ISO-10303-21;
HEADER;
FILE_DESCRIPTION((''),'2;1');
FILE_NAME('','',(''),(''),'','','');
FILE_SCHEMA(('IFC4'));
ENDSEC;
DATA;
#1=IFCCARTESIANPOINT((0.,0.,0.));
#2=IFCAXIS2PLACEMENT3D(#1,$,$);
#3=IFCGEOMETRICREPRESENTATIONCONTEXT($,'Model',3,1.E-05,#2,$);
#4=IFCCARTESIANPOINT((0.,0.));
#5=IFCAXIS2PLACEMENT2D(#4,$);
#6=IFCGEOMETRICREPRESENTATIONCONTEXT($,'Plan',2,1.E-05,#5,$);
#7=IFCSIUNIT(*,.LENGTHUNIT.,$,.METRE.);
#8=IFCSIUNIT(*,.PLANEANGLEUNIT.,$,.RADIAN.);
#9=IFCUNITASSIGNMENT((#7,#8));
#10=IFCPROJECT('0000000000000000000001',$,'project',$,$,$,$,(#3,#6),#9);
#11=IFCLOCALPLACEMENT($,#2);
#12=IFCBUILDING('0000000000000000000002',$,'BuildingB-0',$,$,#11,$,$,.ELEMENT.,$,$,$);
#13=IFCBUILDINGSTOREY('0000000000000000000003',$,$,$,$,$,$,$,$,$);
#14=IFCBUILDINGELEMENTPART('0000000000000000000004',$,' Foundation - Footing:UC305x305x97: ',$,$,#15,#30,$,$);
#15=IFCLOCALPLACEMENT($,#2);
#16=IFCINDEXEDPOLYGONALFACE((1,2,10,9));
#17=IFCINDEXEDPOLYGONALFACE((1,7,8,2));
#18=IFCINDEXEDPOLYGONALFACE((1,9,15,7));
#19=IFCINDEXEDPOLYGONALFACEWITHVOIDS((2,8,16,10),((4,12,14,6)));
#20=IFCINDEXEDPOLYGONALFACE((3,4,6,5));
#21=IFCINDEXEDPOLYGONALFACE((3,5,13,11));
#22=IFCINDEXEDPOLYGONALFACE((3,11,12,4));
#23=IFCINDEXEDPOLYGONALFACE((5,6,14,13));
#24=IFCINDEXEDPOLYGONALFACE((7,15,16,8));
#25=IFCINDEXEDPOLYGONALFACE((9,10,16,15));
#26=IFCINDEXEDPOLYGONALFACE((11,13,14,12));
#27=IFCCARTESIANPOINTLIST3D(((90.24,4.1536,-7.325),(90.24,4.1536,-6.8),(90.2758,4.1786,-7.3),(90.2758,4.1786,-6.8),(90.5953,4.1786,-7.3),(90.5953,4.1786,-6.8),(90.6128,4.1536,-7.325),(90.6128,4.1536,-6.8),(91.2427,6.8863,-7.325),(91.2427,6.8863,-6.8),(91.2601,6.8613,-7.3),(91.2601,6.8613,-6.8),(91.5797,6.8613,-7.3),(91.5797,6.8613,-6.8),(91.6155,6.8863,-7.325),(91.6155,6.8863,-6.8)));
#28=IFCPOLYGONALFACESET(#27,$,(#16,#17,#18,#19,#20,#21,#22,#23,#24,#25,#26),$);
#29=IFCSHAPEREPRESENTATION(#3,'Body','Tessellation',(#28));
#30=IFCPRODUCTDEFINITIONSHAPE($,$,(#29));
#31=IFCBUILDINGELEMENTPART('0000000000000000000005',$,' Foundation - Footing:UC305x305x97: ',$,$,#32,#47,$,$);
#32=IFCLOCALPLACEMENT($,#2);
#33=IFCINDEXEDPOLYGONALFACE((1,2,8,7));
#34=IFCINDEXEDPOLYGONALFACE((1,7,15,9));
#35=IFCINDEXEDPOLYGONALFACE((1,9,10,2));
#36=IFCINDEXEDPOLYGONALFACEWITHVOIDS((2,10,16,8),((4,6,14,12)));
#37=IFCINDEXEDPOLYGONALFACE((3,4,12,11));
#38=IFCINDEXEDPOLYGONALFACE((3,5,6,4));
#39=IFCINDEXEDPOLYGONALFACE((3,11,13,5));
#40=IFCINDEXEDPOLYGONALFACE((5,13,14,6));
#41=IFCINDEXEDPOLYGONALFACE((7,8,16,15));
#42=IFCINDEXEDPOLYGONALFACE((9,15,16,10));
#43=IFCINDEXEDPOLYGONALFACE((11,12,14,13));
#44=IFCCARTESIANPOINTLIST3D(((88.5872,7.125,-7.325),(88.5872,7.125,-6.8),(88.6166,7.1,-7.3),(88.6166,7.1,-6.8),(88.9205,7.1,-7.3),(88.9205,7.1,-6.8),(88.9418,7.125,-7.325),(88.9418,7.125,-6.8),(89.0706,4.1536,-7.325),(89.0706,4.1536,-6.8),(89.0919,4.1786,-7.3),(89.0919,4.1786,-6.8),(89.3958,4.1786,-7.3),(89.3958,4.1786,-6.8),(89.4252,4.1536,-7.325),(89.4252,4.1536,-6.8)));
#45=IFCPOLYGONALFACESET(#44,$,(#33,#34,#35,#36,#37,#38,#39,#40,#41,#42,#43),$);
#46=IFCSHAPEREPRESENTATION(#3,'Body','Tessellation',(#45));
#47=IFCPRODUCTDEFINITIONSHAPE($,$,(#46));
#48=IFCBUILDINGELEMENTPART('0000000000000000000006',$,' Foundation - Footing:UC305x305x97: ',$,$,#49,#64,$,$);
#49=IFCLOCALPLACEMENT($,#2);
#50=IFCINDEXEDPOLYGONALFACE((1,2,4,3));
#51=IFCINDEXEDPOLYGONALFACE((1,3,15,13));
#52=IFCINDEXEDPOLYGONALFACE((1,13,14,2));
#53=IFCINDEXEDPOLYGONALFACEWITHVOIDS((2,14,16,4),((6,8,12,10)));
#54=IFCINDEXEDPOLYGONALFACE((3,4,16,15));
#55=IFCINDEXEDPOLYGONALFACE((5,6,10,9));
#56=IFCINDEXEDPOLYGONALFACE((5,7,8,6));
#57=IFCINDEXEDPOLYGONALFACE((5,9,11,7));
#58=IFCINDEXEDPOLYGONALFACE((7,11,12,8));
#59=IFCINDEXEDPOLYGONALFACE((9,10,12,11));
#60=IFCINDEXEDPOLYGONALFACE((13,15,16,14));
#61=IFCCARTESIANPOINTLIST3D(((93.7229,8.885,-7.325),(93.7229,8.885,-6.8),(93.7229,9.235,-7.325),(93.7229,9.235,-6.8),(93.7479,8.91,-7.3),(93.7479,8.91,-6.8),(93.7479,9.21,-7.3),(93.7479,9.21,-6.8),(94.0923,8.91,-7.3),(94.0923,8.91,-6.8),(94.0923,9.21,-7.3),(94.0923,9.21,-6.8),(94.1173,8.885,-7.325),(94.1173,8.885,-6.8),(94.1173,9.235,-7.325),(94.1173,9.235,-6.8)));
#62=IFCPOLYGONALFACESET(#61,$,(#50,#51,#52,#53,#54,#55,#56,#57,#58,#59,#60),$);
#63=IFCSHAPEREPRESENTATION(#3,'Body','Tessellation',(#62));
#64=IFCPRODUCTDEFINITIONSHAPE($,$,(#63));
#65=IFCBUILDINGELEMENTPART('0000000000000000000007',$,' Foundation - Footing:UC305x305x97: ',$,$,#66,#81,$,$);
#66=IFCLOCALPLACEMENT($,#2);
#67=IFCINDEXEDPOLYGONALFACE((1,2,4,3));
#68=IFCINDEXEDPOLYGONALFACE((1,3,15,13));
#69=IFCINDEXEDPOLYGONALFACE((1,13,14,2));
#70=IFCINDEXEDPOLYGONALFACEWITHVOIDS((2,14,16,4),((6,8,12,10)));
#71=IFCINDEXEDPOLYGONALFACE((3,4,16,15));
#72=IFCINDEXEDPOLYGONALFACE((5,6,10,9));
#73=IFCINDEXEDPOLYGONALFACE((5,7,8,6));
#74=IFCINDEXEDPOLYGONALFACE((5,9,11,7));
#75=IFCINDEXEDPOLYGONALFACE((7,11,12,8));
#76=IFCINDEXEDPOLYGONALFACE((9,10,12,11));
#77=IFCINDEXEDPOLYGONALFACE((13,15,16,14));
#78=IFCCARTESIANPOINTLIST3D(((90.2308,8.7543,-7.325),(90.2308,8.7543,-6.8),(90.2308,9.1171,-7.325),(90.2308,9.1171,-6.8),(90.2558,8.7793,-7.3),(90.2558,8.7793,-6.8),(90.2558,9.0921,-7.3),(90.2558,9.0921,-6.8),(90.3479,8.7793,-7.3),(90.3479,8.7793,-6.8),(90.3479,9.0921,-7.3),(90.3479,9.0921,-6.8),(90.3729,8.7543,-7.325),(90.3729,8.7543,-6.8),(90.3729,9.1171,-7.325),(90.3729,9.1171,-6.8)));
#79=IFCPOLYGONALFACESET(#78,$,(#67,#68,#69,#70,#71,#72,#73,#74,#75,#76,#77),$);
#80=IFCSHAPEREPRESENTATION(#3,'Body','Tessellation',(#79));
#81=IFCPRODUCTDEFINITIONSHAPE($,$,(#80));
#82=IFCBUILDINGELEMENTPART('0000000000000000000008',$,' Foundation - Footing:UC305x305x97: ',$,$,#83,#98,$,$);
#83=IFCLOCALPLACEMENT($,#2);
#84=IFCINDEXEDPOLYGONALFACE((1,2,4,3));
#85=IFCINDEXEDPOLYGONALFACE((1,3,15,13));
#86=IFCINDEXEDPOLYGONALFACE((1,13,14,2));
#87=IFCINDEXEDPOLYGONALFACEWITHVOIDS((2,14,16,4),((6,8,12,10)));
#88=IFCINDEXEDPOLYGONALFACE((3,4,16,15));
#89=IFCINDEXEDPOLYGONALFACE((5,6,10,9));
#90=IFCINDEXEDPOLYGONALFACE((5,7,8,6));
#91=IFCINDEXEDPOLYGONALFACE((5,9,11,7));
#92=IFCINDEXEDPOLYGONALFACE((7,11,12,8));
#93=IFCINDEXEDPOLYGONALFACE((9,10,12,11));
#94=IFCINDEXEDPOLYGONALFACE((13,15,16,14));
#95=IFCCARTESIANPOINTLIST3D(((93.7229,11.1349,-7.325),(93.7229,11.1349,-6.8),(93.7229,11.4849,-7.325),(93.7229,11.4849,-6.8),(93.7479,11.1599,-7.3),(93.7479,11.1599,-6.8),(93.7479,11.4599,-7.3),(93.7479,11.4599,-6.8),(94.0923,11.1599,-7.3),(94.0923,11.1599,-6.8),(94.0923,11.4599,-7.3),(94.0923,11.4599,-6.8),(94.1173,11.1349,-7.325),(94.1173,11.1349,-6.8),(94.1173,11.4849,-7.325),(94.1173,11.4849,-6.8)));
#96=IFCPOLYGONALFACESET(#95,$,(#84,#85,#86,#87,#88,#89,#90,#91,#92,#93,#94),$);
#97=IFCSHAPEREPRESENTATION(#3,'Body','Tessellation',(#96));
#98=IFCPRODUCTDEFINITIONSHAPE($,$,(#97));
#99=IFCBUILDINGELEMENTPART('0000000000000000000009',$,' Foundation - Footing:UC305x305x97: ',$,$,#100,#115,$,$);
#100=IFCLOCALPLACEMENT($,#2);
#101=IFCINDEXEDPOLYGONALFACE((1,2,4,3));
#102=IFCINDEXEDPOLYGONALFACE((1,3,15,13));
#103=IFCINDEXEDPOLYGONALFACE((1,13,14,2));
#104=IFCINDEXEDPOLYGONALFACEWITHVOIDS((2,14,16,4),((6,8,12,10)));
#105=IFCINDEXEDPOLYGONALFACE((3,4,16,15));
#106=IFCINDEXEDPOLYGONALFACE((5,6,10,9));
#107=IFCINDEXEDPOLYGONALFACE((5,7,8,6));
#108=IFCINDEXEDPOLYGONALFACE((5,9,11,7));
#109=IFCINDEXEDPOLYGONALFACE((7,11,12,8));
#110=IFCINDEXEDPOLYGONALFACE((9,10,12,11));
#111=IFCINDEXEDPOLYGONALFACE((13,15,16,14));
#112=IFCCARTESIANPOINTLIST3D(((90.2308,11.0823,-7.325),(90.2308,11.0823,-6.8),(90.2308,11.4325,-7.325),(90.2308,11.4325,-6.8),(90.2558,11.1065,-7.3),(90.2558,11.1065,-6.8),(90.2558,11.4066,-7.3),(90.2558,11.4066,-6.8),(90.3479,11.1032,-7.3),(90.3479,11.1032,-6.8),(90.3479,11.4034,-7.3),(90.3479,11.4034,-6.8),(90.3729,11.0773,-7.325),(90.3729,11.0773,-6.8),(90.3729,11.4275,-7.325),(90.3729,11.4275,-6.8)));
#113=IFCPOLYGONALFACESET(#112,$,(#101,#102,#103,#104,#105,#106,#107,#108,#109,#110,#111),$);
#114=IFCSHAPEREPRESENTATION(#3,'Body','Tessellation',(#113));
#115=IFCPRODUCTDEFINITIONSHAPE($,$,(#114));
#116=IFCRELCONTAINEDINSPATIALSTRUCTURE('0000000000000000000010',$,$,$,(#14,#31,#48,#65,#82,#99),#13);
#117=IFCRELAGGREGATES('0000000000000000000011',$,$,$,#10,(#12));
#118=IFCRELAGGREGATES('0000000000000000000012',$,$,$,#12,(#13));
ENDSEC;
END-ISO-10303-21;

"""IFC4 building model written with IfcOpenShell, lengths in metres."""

from ifc_helpers import new_model, si_unit, origin, origin_2d, place, context, project, spatial, polyline, outline, extrude, element, save


model = new_model("IFC4")

# Units and contexts
model_context = context("Model", 3, precision=1e-05, world=origin())
plan_context = context("Plan", 2, precision=1e-05, world=origin_2d())
ifc_project = project(units=[si_unit("LENGTHUNIT", "METRE"), si_unit("PLANEANGLEUNIT", "RADIAN")], contexts=[model_context, plan_context])

# Building, storey
building_placement = place(None, origin())
building = spatial("IfcBuilding", under=ifc_project, at=building_placement, Name="BuildingB-0", CompositionType="ELEMENT")
storey = spatial("IfcBuildingStorey", under=building)

# Building element parts, openings
building_element_part_1 = element("IfcBuildingElementPart", 1, inside=storey, Name=" Foundation - Footing:UC305x305x97: ", context=model_context, shape_type="SweptSolid", body=[
    extrude(outline(polyline([(90.6128, 4.1536, -7.325), (90.24, 4.1536, -7.325), (91.2427, 6.8863, -7.325), (91.6155, 6.8863, -7.325), (90.6128, 4.1536, -7.325)])), None, (0.0, 0.0, 1.0), 0.525),
])
element("IfcOpeningElement", 2, inside=storey, cuts=building_element_part_1, context=model_context, shape_type="SweptSolid", body=[
    extrude(outline(polyline([(90.5953, 4.1786, -7.3), (90.2758, 4.1786, -7.3), (91.2601, 6.8613, -7.3), (91.5797, 6.8613, -7.3), (90.5953, 4.1786, -7.3)])), None, (0.0, 0.0, 1.0), 0.5),
])
building_element_part_2 = element("IfcBuildingElementPart", 3, inside=storey, Name=" Foundation - Footing:UC305x305x97: ", context=model_context, shape_type="SweptSolid", body=[
    extrude(outline(polyline([(89.4252, 4.1536, -7.325), (89.0706, 4.1536, -7.325), (88.5872, 7.125, -7.325), (88.9418, 7.125, -7.325), (89.4252, 4.1536, -7.325)])), None, (0.0, 0.0, 1.0), 0.525),
])
element("IfcOpeningElement", 4, inside=storey, cuts=building_element_part_2, context=model_context, shape_type="SweptSolid", body=[
    extrude(outline(polyline([(89.3958, 4.1786, -7.3), (89.0919, 4.1786, -7.3), (88.6166, 7.1, -7.3), (88.9205, 7.1, -7.3), (89.3958, 4.1786, -7.3)])), None, (0.0, 0.0, 1.0), 0.5),
])
building_element_part_3 = element("IfcBuildingElementPart", 5, inside=storey, Name=" Foundation - Footing:UC305x305x97: ", context=model_context, shape_type="SweptSolid", body=[
    extrude(outline(polyline([(94.1173, 8.885, -7.325), (94.1173, 9.235, -7.325), (93.7229, 9.235, -7.325), (93.7229, 8.885, -7.325), (94.1173, 8.885, -7.325)])), None, (0.0, 0.0, 1.0), 0.525),
])
element("IfcOpeningElement", 6, inside=storey, cuts=building_element_part_3, context=model_context, shape_type="SweptSolid", body=[
    extrude(outline(polyline([(94.0923, 8.91, -7.3), (94.0923, 9.21, -7.3), (93.7479, 9.21, -7.3), (93.7479, 8.91, -7.3), (94.0923, 8.91, -7.3)])), None, (0.0, 0.0, 1.0), 0.5),
])
building_element_part_4 = element("IfcBuildingElementPart", 7, inside=storey, Name=" Foundation - Footing:UC305x305x97: ", context=model_context, shape_type="SweptSolid", body=[
    extrude(outline(polyline([(90.3729, 8.7543, -7.325), (90.2308, 8.7543, -7.325), (90.2308, 9.1171, -7.325), (90.3729, 9.1171, -7.325), (90.3729, 8.7543, -7.325)])), None, (0.0, 0.0, 1.0), 0.525),
])
element("IfcOpeningElement", 8, inside=storey, cuts=building_element_part_4, context=model_context, shape_type="SweptSolid", body=[
    extrude(outline(polyline([(90.3479, 8.7793, -7.3), (90.2558, 8.7793, -7.3), (90.2558, 9.0921, -7.3), (90.3479, 9.0921, -7.3), (90.3479, 8.7793, -7.3)])), None, (0.0, 0.0, 1.0), 0.5),
])
building_element_part_5 = element("IfcBuildingElementPart", 9, inside=storey, Name=" Foundation - Footing:UC305x305x97: ", context=model_context, shape_type="SweptSolid", body=[
    extrude(outline(polyline([(94.1173, 11.1349, -7.325), (93.7229, 11.1349, -7.325), (93.7229, 11.4849, -7.325), (94.1173, 11.4849, -7.325), (94.1173, 11.1349, -7.325)])), None, (0.0, 0.0, 1.0), 0.525),
])
element("IfcOpeningElement", 10, inside=storey, cuts=building_element_part_5, context=model_context, shape_type="SweptSolid", body=[
    extrude(outline(polyline([(94.0923, 11.1599, -7.3), (93.7479, 11.1599, -7.3), (93.7479, 11.4599, -7.3), (94.0923, 11.4599, -7.3), (94.0923, 11.1599, -7.3)])), None, (0.0, 0.0, 1.0), 0.5),
])
building_element_part_6 = element("IfcBuildingElementPart", 11, inside=storey, Name=" Foundation - Footing:UC305x305x97: ", context=model_context, shape_type="SweptSolid", body=[
    extrude(outline(polyline([(90.3729, 11.0773, -7.325), (90.2308, 11.0823, -7.325), (90.2308, 11.4325, -7.325), (90.3729, 11.4275, -7.325), (90.3729, 11.0773, -7.325)])), None, (0.0, 0.0, 1.0), 0.525),
])
element("IfcOpeningElement", 12, inside=storey, cuts=building_element_part_6, context=model_context, shape_type="SweptSolid", body=[
    extrude(outline(polyline([(90.3479, 11.1032, -7.3), (90.2558, 11.1065, -7.3), (90.2558, 11.4066, -7.3), (90.3479, 11.4034, -7.3), (90.3479, 11.1032, -7.3)])), None, (0.0, 0.0, 1.0), 0.5),
])

save(model, "model.ifc")
